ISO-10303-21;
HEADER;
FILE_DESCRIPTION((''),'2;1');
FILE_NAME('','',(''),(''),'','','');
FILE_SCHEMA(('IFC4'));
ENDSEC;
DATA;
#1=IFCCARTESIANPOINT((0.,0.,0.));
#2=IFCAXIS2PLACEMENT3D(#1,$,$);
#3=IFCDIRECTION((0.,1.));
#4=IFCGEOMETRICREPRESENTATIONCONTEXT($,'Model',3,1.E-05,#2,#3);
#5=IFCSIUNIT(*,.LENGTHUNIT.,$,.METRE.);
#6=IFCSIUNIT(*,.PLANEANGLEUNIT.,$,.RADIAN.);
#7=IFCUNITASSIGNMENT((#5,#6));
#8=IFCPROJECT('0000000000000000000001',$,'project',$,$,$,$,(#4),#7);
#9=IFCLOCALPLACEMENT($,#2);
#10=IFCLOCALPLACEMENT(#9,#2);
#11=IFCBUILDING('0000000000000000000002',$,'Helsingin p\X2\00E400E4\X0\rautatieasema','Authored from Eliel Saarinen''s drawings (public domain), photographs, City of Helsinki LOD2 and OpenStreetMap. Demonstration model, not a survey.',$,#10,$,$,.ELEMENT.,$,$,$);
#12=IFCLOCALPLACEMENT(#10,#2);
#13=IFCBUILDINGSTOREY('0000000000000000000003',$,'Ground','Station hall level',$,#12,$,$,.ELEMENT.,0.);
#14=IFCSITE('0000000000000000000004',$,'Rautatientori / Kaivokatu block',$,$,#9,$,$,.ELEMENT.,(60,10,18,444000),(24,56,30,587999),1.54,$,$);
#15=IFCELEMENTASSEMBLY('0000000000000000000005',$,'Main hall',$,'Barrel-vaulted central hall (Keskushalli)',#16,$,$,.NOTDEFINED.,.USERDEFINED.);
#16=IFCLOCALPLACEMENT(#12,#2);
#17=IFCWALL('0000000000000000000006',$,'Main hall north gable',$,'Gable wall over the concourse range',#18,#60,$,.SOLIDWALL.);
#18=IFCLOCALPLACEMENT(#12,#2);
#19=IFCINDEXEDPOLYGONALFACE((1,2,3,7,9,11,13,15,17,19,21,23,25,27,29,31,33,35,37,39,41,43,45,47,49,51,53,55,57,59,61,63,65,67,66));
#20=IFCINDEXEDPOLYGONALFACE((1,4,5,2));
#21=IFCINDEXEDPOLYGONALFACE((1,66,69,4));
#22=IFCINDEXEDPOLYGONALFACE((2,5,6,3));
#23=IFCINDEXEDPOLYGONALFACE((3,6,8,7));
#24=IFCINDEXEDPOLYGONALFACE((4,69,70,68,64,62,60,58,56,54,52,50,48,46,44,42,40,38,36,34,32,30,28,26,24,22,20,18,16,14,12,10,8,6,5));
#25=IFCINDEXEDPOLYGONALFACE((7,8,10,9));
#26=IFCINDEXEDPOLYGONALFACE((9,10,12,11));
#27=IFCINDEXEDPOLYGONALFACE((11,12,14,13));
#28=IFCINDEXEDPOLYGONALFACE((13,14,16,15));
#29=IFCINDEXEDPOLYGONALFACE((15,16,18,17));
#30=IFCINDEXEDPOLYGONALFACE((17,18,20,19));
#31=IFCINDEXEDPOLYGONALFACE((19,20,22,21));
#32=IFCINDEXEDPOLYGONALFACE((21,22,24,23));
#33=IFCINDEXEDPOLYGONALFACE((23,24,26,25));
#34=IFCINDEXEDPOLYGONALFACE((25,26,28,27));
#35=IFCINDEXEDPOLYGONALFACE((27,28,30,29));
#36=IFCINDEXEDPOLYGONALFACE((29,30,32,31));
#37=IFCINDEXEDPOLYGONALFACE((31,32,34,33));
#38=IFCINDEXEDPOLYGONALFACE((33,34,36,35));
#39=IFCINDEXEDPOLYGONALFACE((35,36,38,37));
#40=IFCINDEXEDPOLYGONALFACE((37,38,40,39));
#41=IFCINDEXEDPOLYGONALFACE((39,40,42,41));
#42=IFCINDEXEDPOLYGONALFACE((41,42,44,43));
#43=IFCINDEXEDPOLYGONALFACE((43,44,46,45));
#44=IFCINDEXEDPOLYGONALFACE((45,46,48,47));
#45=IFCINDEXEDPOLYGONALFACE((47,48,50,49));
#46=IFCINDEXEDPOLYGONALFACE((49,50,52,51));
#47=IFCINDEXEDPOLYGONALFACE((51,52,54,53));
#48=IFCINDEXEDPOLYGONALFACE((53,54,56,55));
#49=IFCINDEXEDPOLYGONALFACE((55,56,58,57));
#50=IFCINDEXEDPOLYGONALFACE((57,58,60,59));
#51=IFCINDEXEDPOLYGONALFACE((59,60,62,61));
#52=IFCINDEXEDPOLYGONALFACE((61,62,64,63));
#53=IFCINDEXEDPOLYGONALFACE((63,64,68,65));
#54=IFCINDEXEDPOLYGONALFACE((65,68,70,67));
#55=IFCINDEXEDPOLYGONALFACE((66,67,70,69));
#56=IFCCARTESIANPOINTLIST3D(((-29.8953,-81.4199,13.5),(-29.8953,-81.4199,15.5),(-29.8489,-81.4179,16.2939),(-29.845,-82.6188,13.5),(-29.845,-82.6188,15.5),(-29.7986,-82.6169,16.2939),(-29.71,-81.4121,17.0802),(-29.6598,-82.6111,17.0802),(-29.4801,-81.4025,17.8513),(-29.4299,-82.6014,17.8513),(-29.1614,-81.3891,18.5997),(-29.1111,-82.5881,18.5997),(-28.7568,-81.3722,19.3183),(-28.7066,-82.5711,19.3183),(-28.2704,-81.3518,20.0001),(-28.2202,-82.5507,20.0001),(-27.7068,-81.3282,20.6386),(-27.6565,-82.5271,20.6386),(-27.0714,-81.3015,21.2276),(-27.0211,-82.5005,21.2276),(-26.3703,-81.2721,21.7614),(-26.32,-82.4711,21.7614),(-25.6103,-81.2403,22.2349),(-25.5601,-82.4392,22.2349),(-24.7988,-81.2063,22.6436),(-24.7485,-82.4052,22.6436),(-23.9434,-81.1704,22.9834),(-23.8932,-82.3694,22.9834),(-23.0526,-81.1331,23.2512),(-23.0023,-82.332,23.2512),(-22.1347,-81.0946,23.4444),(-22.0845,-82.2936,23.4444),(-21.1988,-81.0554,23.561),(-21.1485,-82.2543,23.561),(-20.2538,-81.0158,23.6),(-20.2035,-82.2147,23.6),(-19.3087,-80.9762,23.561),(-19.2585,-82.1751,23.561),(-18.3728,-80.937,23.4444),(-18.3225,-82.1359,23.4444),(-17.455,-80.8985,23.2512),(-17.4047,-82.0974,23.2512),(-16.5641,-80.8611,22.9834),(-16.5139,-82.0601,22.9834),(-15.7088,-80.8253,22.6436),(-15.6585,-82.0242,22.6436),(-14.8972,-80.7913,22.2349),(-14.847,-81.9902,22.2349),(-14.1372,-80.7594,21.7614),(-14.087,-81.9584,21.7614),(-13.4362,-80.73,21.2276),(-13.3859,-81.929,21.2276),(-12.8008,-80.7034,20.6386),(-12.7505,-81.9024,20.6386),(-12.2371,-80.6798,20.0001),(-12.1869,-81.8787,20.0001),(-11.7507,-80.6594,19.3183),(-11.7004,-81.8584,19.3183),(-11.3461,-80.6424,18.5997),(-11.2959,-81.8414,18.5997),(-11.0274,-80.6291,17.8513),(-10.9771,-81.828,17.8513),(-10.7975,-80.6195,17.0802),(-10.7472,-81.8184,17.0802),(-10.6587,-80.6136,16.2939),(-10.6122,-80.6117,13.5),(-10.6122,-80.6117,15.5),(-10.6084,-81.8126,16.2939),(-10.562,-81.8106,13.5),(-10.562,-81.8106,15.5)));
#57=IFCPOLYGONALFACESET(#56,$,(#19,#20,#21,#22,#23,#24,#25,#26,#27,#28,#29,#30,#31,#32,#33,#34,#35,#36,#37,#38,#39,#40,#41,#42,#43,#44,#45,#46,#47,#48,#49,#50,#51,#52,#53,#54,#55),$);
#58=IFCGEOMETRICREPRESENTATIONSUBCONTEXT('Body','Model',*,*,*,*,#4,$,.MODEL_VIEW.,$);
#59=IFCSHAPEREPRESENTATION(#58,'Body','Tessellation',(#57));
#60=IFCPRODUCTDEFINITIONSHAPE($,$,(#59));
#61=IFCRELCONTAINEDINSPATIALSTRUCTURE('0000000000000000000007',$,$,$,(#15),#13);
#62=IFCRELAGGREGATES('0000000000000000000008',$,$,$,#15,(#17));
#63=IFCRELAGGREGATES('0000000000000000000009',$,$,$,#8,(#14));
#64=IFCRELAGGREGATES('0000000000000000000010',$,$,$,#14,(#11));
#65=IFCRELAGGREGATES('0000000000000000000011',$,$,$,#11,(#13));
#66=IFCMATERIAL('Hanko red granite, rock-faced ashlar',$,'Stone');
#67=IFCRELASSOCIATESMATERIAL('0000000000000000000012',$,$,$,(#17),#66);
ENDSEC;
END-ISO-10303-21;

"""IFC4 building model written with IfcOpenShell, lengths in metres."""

from ifc_helpers import new_model, si_unit, direction, frame, origin, place, context, subcontext, project, spatial, polyline, outline, extrude, material, element, aggregate, save


model = new_model("IFC4")

# Units and contexts
model_context = context("Model", 3, precision=1e-05, world=origin(), true_north=direction((0.0, 1.0)))
body_context = subcontext(model_context, "Body", "Model", "MODEL_VIEW")
ifc_project = project(units=[si_unit("LENGTHUNIT", "METRE"), si_unit("PLANEANGLEUNIT", "RADIAN")], contexts=[model_context])

# Site, building, storey
site_placement = place(None, origin())
site = spatial("IfcSite", under=ifc_project, at=site_placement, Name="Rautatientori / Kaivokatu block", CompositionType="ELEMENT", RefLatitude=(60, 10, 18, 444000), RefLongitude=(24, 56, 30, 587999), RefElevation=1.54)
building_placement = place(site_placement, origin())
building = spatial("IfcBuilding", under=site, at=building_placement, Name="Helsingin päärautatieasema", Description="Authored from Eliel Saarinen's drawings (public domain), photographs, City of Helsinki LOD2 and OpenStreetMap. Demonstration model, not a survey.", CompositionType="ELEMENT")
storey_placement = place(building_placement, origin())
storey = spatial("IfcBuildingStorey", under=building, at=storey_placement, Name="Ground", Description="Station hall level", CompositionType="ELEMENT", Elevation=0.0)

# Element assembly, wall
assembly_1_placement = place(building_placement, origin())
assembly_1 = element("IfcElementAssembly", 1, at=assembly_1_placement, inside=storey, Name="Main hall", ObjectType="Barrel-vaulted central hall (Keskushalli)", AssemblyPlace="NOTDEFINED", PredefinedType="USERDEFINED")
ifc_material_1 = material(Name="Hanko red granite, rock-faced ashlar", Category="Stone")
wall_1_placement = place(building_placement, origin())
wall_1 = element("IfcWall", 2, at=wall_1_placement, material=ifc_material_1, Name="Main hall north gable", ObjectType="Gable wall over the concourse range", PredefinedType="SOLIDWALL", context=body_context, shape_type="SweptSolid", body=[
    extrude(outline(polyline([(9.65, 0.0), (9.6035, 0.7939), (9.4646, 1.5802), (9.2345, 2.3513), (8.9154, 3.0997), (8.5105, 3.8183), (8.0237, 4.5001), (7.4596, 5.1386), (6.8236, 5.7276), (6.1219, 6.2614), (5.3613, 6.7349), (4.549, 7.1436), (3.6929, 7.4834), (2.8012, 7.7512), (1.8826, 7.9444), (0.9459, 8.061), (0.0, 8.1), (-0.9459, 8.061), (-1.8826, 7.9444), (-2.8012, 7.7512), (-3.6929, 7.4834), (-4.549, 7.1436), (-5.3613, 6.7349), (-6.1219, 6.2614), (-6.8236, 5.7276), (-7.4596, 5.1386), (-8.0237, 4.5001), (-8.5105, 3.8183), (-8.9154, 3.0997), (-9.2345, 2.3513), (-9.4646, 1.5802), (-9.6035, 0.7939), (-9.65, 0.0), (-9.65, -2.0), (9.65, -2.0), (9.65, 0.0)])), frame((-20.2538, -81.0158, 15.5), z_axis=(0.041876, -0.999123, 0.0), x_axis=(0.999123, 0.041876, 0.0)), (0.0, 0.0, 1.0), 1.2),
])
aggregate(assembly_1, [wall_1])

save(model, "model.ifc")
